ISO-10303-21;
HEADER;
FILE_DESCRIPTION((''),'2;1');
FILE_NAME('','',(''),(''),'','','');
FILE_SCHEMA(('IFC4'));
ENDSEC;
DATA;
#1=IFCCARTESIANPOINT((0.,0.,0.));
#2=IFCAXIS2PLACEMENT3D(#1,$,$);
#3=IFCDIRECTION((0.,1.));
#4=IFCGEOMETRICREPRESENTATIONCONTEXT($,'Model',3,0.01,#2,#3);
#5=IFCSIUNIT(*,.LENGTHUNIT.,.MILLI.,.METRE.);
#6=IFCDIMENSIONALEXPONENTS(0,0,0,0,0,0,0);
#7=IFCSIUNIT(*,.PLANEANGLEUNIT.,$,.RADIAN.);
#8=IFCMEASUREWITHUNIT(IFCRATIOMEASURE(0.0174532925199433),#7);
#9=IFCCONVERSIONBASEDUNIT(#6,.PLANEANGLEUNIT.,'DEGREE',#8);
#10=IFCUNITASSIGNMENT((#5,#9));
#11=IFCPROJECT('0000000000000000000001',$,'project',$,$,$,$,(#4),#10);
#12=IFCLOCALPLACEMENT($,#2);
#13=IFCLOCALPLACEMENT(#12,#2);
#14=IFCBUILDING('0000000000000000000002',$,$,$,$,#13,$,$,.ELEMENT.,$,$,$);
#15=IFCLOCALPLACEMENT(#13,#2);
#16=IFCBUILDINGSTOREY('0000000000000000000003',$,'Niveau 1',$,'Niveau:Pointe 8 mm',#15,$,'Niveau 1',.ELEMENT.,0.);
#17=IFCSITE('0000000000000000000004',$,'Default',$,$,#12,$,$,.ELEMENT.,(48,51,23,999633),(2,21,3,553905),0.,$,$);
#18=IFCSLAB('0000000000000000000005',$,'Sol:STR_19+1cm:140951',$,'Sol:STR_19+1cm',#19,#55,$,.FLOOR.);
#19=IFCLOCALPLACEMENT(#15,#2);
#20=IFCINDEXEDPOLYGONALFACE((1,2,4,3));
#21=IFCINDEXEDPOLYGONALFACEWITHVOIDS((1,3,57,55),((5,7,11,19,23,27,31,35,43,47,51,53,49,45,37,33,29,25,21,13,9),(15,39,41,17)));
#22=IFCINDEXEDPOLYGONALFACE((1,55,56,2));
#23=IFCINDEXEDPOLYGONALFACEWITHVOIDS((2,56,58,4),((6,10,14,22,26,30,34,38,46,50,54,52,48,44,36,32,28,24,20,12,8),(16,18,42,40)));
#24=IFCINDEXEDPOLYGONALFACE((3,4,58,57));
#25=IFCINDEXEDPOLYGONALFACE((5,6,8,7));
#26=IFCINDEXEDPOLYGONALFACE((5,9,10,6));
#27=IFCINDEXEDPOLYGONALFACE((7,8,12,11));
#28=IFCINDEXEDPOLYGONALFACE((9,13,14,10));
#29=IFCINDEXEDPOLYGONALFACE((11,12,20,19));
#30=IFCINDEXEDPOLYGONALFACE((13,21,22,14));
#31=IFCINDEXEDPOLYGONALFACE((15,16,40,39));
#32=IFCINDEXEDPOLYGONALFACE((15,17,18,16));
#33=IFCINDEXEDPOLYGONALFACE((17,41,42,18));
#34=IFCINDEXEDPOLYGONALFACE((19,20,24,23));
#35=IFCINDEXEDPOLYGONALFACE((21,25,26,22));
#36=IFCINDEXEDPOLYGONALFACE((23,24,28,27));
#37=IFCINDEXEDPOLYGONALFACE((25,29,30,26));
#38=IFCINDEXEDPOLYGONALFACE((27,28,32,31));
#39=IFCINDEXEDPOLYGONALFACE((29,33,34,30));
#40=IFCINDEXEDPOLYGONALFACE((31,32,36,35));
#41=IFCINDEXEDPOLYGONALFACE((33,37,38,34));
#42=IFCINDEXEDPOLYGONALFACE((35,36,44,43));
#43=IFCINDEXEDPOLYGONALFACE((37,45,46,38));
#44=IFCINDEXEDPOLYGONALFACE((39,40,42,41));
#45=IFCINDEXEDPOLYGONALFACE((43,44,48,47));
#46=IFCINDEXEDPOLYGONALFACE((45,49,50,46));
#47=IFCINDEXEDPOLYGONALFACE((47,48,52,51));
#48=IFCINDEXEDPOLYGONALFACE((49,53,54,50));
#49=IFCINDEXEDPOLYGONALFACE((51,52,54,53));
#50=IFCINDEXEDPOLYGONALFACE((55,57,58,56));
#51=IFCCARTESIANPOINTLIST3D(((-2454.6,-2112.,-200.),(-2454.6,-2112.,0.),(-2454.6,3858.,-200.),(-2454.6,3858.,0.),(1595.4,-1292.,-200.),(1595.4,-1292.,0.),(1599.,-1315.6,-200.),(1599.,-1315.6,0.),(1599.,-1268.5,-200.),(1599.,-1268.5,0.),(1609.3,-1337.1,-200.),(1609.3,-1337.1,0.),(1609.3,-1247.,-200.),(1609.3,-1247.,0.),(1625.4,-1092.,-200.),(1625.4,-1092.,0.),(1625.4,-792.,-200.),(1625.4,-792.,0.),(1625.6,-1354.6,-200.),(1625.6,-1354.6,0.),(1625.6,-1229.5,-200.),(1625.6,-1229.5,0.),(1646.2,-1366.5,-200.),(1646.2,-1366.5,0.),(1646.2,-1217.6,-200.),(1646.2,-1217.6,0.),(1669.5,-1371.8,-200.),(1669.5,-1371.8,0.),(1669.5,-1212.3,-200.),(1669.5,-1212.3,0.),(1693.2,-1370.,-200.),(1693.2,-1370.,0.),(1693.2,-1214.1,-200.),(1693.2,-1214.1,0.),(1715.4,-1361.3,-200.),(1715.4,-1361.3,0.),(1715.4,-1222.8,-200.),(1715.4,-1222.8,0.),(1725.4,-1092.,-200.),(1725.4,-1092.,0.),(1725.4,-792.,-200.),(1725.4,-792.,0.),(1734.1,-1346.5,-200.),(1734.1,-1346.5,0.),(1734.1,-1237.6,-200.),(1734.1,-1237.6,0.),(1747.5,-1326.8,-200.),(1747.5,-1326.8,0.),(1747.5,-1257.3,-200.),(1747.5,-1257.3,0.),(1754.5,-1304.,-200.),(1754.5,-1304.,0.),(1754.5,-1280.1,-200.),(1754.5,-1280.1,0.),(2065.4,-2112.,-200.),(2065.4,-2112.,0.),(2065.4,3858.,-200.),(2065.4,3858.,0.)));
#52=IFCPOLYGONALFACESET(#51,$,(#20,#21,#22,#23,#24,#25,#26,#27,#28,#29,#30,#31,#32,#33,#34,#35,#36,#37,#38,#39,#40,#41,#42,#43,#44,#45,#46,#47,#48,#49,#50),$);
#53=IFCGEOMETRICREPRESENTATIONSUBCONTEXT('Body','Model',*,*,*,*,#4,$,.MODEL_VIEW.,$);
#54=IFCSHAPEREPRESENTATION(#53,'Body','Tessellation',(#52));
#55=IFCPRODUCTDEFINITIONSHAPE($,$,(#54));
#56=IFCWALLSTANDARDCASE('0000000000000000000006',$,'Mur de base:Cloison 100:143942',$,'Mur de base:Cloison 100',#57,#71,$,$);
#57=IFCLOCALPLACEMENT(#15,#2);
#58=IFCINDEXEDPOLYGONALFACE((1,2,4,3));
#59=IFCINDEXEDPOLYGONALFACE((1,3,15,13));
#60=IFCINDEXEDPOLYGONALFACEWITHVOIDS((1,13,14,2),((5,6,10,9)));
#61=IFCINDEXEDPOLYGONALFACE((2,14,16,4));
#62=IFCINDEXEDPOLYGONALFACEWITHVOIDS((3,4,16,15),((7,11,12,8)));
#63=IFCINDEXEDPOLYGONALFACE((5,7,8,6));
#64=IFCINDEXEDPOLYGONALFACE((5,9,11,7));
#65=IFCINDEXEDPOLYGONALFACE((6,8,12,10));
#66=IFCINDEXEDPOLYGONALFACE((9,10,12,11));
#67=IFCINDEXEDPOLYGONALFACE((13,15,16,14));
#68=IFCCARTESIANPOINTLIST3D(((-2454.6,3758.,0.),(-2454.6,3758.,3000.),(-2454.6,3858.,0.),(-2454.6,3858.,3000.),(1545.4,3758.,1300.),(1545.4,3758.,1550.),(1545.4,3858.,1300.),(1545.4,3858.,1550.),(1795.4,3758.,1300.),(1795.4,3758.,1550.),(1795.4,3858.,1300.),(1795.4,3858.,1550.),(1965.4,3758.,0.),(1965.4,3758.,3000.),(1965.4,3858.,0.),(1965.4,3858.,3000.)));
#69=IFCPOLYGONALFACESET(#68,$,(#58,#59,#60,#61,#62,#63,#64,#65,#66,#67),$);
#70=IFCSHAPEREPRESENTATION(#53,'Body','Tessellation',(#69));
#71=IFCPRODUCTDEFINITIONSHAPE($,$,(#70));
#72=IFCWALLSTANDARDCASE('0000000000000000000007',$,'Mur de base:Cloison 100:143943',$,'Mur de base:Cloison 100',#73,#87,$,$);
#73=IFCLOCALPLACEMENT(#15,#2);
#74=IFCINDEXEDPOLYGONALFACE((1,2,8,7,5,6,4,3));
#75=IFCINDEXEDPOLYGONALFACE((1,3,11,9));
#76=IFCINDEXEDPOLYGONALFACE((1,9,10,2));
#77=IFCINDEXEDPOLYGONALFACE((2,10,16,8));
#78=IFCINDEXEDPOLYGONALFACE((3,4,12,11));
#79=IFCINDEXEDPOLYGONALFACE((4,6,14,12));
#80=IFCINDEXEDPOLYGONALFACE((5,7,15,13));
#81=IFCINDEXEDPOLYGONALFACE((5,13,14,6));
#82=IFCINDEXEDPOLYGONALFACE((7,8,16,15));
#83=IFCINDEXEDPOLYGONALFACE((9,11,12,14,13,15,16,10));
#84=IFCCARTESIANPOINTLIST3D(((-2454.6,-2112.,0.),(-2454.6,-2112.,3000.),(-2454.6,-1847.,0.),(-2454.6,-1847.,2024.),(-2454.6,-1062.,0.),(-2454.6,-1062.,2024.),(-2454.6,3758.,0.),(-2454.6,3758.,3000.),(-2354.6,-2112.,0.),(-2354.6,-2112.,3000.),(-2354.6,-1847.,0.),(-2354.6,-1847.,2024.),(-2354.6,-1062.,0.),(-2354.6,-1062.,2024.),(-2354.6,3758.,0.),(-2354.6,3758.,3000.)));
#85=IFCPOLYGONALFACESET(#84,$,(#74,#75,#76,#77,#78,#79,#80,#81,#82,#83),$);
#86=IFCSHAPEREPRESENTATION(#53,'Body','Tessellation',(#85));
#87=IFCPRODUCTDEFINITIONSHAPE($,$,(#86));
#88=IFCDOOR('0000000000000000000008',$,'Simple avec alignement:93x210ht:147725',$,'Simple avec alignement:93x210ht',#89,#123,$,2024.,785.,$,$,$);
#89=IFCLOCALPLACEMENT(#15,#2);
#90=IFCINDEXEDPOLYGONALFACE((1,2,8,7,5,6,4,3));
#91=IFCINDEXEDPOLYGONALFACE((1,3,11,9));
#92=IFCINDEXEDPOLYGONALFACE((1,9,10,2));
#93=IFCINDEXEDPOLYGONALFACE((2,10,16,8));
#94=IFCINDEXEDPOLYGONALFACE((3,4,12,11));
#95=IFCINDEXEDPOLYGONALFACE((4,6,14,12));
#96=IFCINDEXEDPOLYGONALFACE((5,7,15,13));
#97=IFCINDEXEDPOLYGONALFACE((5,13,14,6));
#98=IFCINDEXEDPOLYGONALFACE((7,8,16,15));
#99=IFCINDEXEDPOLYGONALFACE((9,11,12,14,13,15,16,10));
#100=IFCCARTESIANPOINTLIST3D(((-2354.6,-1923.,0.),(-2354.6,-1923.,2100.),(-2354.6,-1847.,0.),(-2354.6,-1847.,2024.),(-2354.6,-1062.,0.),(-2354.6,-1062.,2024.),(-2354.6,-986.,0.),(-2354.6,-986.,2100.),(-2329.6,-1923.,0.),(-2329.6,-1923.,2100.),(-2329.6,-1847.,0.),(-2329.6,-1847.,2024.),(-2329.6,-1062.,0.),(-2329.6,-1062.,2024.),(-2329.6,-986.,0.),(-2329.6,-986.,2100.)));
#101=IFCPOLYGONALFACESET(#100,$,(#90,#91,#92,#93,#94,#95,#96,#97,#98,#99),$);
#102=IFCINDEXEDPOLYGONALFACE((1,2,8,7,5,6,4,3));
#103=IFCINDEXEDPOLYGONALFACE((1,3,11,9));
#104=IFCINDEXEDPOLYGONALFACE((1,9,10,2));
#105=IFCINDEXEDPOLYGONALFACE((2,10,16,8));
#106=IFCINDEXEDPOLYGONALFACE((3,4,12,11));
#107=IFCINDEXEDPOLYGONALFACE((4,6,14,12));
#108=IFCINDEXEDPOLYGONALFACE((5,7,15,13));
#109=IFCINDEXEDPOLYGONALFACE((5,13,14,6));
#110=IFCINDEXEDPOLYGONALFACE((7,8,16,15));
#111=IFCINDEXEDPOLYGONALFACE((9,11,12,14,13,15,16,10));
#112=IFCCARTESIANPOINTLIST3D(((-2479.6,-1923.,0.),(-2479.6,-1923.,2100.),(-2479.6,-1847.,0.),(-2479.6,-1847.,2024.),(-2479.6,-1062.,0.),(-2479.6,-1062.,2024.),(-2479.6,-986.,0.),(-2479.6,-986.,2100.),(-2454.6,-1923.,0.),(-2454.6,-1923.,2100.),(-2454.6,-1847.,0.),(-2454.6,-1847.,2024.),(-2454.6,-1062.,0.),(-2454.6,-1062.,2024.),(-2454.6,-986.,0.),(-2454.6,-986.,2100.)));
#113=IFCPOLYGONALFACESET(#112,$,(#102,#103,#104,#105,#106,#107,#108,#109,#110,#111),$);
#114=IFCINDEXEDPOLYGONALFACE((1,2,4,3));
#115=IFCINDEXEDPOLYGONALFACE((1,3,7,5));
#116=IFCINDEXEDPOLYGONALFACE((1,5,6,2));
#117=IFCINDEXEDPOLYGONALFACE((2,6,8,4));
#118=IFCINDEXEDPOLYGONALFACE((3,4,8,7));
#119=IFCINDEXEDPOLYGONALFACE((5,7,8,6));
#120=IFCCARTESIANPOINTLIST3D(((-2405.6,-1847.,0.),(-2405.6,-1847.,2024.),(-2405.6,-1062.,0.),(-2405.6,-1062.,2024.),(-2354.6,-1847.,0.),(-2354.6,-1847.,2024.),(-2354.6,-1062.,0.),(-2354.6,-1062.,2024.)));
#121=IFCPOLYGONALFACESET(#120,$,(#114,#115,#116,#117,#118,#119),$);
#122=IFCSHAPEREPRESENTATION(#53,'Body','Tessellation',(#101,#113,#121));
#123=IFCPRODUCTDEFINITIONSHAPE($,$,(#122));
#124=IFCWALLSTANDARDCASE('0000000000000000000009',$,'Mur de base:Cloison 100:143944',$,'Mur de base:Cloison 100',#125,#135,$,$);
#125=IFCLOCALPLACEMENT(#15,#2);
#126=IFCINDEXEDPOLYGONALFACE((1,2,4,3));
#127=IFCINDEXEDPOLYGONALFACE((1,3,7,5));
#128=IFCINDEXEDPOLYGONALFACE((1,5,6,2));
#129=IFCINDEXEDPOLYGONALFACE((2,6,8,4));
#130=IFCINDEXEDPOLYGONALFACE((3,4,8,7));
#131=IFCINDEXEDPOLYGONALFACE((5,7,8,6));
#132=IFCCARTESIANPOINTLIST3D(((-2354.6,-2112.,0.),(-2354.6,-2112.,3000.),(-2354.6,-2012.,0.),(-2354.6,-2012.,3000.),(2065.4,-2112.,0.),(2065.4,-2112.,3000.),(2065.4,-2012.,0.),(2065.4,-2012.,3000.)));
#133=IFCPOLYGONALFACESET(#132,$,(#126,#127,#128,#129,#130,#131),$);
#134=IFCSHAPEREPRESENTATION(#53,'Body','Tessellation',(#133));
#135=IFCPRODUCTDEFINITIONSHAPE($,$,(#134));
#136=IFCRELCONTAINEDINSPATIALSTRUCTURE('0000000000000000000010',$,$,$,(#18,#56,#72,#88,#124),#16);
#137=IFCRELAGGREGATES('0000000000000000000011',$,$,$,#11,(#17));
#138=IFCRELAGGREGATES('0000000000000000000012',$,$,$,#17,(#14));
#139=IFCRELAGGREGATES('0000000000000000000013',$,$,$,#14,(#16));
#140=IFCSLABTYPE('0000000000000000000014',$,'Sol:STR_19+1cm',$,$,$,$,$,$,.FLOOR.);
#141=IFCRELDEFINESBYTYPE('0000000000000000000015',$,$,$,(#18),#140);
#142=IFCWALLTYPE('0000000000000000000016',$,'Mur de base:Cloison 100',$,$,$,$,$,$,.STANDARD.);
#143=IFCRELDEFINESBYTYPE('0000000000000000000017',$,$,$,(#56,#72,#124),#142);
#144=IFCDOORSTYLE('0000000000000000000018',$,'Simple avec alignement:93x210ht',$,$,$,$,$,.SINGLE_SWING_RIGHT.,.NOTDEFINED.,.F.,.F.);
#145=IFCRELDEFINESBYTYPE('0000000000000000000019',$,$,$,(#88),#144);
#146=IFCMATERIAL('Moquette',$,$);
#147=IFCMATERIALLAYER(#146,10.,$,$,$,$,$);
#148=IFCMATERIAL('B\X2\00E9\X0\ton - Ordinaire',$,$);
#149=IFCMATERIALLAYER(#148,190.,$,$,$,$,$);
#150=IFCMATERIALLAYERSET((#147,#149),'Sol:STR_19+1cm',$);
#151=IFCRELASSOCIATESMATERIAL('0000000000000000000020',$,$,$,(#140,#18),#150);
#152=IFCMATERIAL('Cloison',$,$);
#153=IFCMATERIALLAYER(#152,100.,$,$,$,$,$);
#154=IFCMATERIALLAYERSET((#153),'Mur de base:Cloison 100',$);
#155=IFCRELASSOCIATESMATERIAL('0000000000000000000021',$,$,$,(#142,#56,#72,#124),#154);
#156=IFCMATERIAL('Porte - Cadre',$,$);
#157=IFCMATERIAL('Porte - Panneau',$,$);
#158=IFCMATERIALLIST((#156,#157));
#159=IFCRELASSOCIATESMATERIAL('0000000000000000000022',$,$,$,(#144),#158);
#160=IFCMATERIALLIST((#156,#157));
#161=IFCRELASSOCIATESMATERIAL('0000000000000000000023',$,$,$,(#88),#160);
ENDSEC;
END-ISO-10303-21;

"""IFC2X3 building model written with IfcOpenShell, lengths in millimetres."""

from ifc_helpers import new_model, entity, si_unit, converted_unit, direction, frame, frame_2d, origin, origin_2d_with_axis, place, context, subcontext, project, spatial, polyline, rectangle, circle, outline, extrude, source, transform, mapped, material, material_list, layer, layer_set, layer_usage, type_object, type_shapes, element, fill, save


model = new_model("IFC2X3")

# Units and contexts
model_context = context("Model", 3, precision=0.01, world=origin(), true_north=direction((0.0, 1.0)))
body_context = subcontext(model_context, "Body", "Model", "MODEL_VIEW")
ifc_project = project(units=[si_unit("LENGTHUNIT", "METRE", prefix="MILLI"), converted_unit("PLANEANGLEUNIT", "DEGREE", entity("IfcRatioMeasure", 0.0174532925199433), si_unit("PLANEANGLEUNIT", "RADIAN"), dimensions=[0, 0, 0, 0, 0, 0, 0])], contexts=[model_context])

# Site, building, storey
site_placement = place(None, origin())
site = spatial("IfcSite", under=ifc_project, at=site_placement, Name="Default", CompositionType="ELEMENT", RefLatitude=(48, 51, 23, 999633), RefLongitude=(2, 21, 3, 553905), RefElevation=0.0)
building_placement = place(site_placement, origin())
building = spatial("IfcBuilding", under=site, at=building_placement, CompositionType="ELEMENT")
storey_placement = place(building_placement, origin())
storey = spatial("IfcBuildingStorey", under=building, at=storey_placement, Name="Niveau 1", ObjectType="Niveau:Pointe 8 mm", LongName="Niveau 1", CompositionType="ELEMENT", Elevation=0.0)

# Slab, openings
ifc_material_1 = material(Name="Moquette")
ifc_layer_1 = layer(ifc_material_1, 10.0)
ifc_material_2 = material(Name="Béton - Ordinaire")
ifc_layer_2 = layer(ifc_material_2, 190.0)
ifc_layer_set_1 = layer_set([ifc_layer_1, ifc_layer_2], Name="Sol:STR_19+1cm")
ifc_layer_usage_1 = layer_usage(ifc_layer_set_1, "AXIS3", "POSITIVE", 0.0)
slab_type = type_object("IfcSlabType", Name="Sol:STR_19+1cm", PredefinedType="FLOOR", material=ifc_layer_set_1)
slab_placement = place(storey_placement, origin())
slab = element("IfcSlab", 1, at=slab_placement, inside=storey, type_object=slab_type, material=ifc_layer_usage_1, Name="Sol:STR_19+1cm:140951", ObjectType="Sol:STR_19+1cm", PredefinedType="FLOOR", context=body_context, shape_type="SweptSolid", body=[
    extrude(rectangle(XDim=4520.0, YDim=5970.0, at=origin_2d_with_axis()), frame((-194.6, 873.0, 0.0), z_axis=(0.0, 0.0, -1.0), x_axis=(-1.0, 0.0, 0.0)), (0.0, 0.0, 1.0), 200.0),
])
opening_1_placement = place(slab_placement, origin())
element("IfcOpeningElement", 2, at=opening_1_placement, cuts=slab, ObjectType="Opening", context=body_context, shape_type="SweptSolid", body=[
    extrude(circle(Radius=80.0, at=origin_2d_with_axis()), frame((1675.4, -1292.0, -1524.0), z_axis=(0.0, 0.0, 1.0), x_axis=(-1.0, 0.0, 0.0)), (0.0, 0.0, 1.0), 3048.0),
])
opening_2_placement = place(slab_placement, origin())
element("IfcOpeningElement", 3, at=opening_2_placement, cuts=slab, ObjectType="Opening", context=body_context, shape_type="SweptSolid", body=[
    extrude(rectangle(XDim=300.0, YDim=100.0, at=origin_2d_with_axis()), frame((1675.4, -942.0, -1524.0), z_axis=(0.0, 0.0, 1.0), x_axis=(0.0, 1.0, 0.0)), (0.0, 0.0, 1.0), 3048.0),
])

# Wall, opening
ifc_material_3 = material(Name="Cloison")
ifc_layer_3 = layer(ifc_material_3, 100.0)
ifc_layer_set_2 = layer_set([ifc_layer_3], Name="Mur de base:Cloison 100")
ifc_layer_usage_2 = layer_usage(ifc_layer_set_2, "AXIS2", "NEGATIVE", 50.0)
wall_type = type_object("IfcWallType", Name="Mur de base:Cloison 100", PredefinedType="STANDARD", material=ifc_layer_set_2)
wall_1_placement = place(storey_placement, frame((-2454.6, 3808.0, 0.0)))
wall_1 = element("IfcWallStandardCase", 4, at=wall_1_placement, inside=storey, type_object=wall_type, material=ifc_layer_usage_2, Name="Mur de base:Cloison 100:143942", ObjectType="Mur de base:Cloison 100", context=body_context, shape_type="SweptSolid", body=[
    extrude(rectangle(XDim=4420.0, YDim=100.0, at=frame_2d((2210.0, 0.0), x_axis=(-1.0, 0.0))), origin(), (0.0, 0.0, 1.0), 3000.0),
])
opening_3_placement = place(wall_1_placement, origin())
element("IfcOpeningElement", 5, at=opening_3_placement, cuts=wall_1, ObjectType="Opening", context=body_context, shape_type="SweptSolid", body=[
    extrude(rectangle(XDim=250.0, YDim=250.0, at=origin_2d_with_axis()), frame((4125.0, -1574.0, 1425.0), z_axis=(0.0, 1.0, 0.0), x_axis=(0.0, 0.0, 1.0)), (0.0, 0.0, 1.0), 3048.0),
])

# Wall, opening, door
ifc_layer_usage_3 = layer_usage(ifc_layer_set_2, "AXIS2", "NEGATIVE", 50.0)
wall_2_placement = place(storey_placement, frame((-2404.6, -2112.0, 0.0), z_axis=(0.0, 0.0, 1.0), x_axis=(0.0, 1.0, 0.0)))
wall_2 = element("IfcWallStandardCase", 6, at=wall_2_placement, inside=storey, type_object=wall_type, material=ifc_layer_usage_3, Name="Mur de base:Cloison 100:143943", ObjectType="Mur de base:Cloison 100", context=body_context, shape_type="SweptSolid", body=[
    extrude(rectangle(XDim=5870.0, YDim=100.0, at=frame_2d((2935.0, 0.0), x_axis=(-1.0, 0.0))), origin(), (0.0, 0.0, 1.0), 3000.0),
])
opening_4_placement = place(wall_2_placement, frame((1050.0, 50.0, 0.0)))
opening_4 = element("IfcOpeningElement", 7, at=opening_4_placement, cuts=wall_2, ObjectType="Opening", context=body_context, shape_type="SweptSolid", body=[
    extrude(rectangle(XDim=785.0, YDim=2024.0, at=frame_2d((1012.0, 392.5), x_axis=(0.0, 1.0))), frame((0.0, 0.0, 0.0), z_axis=(0.0, -1.0, 0.0), x_axis=(0.0, 0.0, 1.0)), (0.0, 0.0, 1.0), 100.0),
])
ifc_material_4 = material(Name="Porte - Cadre")
ifc_material_5 = material(Name="Porte - Panneau")
ifc_material_list_1 = material_list([ifc_material_4, ifc_material_5])
ifc_material_list_2 = material_list([ifc_material_4, ifc_material_5])
door_style = type_object("IfcDoorStyle", Name="Simple avec alignement:93x210ht", ConstructionType="NOTDEFINED", OperationType="SINGLE_SWING_RIGHT", ParameterTakesPrecedence=False, Sizeable=False, material=ifc_material_list_2)
shared_shape_1 = source(origin(), body_context, "Body", "SweptSolid", [
    extrude(outline(polyline([(-468.5, -1069.0), (468.5, -1069.0), (468.5, 1031.0), (392.5, 1031.0), (392.5, -993.0), (-392.5, -993.0), (-392.5, 1031.0), (-468.5, 1031.0), (-468.5, -1069.0)])), frame((392.5, 100.0, 1031.0), z_axis=(0.0, 1.0, 0.0), x_axis=(1.0, 0.0, 0.0)), (0.0, 0.0, 1.0), 25.0),
    extrude(outline(polyline([(-1069.0, -468.5), (1031.0, -468.5), (1031.0, -392.5), (-993.0, -392.5), (-993.0, 392.5), (1031.0, 392.5), (1031.0, 468.5), (-1069.0, 468.5), (-1069.0, -468.5)])), frame((392.5, -25.0, 1031.0), z_axis=(0.0, 1.0, 0.0), x_axis=(0.0, 0.0, -1.0)), (0.0, 0.0, 1.0), 25.0),
    extrude(rectangle(XDim=51.0, YDim=785.0, at=origin_2d_with_axis()), frame((392.5, 74.5, 0.0), z_axis=(0.0, 0.0, 1.0), x_axis=(0.0, 1.0, 0.0)), (0.0, 0.0, 1.0), 2024.0),
])
type_shapes(door_style, [shared_shape_1])
door_placement = place(opening_4_placement, frame((0.0, 0.0, 0.0), z_axis=(0.0, 0.0, 1.0), x_axis=(-1.0, 0.0, 0.0)))
door = element("IfcDoor", 8, at=door_placement, inside=storey, type_object=door_style, material=ifc_material_list_1, Name="Simple avec alignement:93x210ht:147725", ObjectType="Simple avec alignement:93x210ht", OverallHeight=2024.0, OverallWidth=785.0, context=body_context, shape_type="MappedRepresentation", body=[
    mapped(shared_shape_1, transform((0.0, 0.0, 0.0), scale=1.0)),
])
fill(opening_4, door)

# Wall
ifc_layer_usage_4 = layer_usage(ifc_layer_set_2, "AXIS2", "NEGATIVE", 50.0)
wall_3_placement = place(storey_placement, frame((2065.4, -2062.0, 0.0), z_axis=(0.0, 0.0, 1.0), x_axis=(-1.0, 0.0, 0.0)))
element("IfcWallStandardCase", 9, at=wall_3_placement, inside=storey, type_object=wall_type, material=ifc_layer_usage_4, Name="Mur de base:Cloison 100:143944", ObjectType="Mur de base:Cloison 100", context=body_context, shape_type="SweptSolid", body=[
    extrude(rectangle(XDim=4420.0, YDim=100.0, at=frame_2d((2210.0, 0.0), x_axis=(-1.0, 0.0))), origin(), (0.0, 0.0, 1.0), 3000.0),
])

save(model, "model.ifc")
